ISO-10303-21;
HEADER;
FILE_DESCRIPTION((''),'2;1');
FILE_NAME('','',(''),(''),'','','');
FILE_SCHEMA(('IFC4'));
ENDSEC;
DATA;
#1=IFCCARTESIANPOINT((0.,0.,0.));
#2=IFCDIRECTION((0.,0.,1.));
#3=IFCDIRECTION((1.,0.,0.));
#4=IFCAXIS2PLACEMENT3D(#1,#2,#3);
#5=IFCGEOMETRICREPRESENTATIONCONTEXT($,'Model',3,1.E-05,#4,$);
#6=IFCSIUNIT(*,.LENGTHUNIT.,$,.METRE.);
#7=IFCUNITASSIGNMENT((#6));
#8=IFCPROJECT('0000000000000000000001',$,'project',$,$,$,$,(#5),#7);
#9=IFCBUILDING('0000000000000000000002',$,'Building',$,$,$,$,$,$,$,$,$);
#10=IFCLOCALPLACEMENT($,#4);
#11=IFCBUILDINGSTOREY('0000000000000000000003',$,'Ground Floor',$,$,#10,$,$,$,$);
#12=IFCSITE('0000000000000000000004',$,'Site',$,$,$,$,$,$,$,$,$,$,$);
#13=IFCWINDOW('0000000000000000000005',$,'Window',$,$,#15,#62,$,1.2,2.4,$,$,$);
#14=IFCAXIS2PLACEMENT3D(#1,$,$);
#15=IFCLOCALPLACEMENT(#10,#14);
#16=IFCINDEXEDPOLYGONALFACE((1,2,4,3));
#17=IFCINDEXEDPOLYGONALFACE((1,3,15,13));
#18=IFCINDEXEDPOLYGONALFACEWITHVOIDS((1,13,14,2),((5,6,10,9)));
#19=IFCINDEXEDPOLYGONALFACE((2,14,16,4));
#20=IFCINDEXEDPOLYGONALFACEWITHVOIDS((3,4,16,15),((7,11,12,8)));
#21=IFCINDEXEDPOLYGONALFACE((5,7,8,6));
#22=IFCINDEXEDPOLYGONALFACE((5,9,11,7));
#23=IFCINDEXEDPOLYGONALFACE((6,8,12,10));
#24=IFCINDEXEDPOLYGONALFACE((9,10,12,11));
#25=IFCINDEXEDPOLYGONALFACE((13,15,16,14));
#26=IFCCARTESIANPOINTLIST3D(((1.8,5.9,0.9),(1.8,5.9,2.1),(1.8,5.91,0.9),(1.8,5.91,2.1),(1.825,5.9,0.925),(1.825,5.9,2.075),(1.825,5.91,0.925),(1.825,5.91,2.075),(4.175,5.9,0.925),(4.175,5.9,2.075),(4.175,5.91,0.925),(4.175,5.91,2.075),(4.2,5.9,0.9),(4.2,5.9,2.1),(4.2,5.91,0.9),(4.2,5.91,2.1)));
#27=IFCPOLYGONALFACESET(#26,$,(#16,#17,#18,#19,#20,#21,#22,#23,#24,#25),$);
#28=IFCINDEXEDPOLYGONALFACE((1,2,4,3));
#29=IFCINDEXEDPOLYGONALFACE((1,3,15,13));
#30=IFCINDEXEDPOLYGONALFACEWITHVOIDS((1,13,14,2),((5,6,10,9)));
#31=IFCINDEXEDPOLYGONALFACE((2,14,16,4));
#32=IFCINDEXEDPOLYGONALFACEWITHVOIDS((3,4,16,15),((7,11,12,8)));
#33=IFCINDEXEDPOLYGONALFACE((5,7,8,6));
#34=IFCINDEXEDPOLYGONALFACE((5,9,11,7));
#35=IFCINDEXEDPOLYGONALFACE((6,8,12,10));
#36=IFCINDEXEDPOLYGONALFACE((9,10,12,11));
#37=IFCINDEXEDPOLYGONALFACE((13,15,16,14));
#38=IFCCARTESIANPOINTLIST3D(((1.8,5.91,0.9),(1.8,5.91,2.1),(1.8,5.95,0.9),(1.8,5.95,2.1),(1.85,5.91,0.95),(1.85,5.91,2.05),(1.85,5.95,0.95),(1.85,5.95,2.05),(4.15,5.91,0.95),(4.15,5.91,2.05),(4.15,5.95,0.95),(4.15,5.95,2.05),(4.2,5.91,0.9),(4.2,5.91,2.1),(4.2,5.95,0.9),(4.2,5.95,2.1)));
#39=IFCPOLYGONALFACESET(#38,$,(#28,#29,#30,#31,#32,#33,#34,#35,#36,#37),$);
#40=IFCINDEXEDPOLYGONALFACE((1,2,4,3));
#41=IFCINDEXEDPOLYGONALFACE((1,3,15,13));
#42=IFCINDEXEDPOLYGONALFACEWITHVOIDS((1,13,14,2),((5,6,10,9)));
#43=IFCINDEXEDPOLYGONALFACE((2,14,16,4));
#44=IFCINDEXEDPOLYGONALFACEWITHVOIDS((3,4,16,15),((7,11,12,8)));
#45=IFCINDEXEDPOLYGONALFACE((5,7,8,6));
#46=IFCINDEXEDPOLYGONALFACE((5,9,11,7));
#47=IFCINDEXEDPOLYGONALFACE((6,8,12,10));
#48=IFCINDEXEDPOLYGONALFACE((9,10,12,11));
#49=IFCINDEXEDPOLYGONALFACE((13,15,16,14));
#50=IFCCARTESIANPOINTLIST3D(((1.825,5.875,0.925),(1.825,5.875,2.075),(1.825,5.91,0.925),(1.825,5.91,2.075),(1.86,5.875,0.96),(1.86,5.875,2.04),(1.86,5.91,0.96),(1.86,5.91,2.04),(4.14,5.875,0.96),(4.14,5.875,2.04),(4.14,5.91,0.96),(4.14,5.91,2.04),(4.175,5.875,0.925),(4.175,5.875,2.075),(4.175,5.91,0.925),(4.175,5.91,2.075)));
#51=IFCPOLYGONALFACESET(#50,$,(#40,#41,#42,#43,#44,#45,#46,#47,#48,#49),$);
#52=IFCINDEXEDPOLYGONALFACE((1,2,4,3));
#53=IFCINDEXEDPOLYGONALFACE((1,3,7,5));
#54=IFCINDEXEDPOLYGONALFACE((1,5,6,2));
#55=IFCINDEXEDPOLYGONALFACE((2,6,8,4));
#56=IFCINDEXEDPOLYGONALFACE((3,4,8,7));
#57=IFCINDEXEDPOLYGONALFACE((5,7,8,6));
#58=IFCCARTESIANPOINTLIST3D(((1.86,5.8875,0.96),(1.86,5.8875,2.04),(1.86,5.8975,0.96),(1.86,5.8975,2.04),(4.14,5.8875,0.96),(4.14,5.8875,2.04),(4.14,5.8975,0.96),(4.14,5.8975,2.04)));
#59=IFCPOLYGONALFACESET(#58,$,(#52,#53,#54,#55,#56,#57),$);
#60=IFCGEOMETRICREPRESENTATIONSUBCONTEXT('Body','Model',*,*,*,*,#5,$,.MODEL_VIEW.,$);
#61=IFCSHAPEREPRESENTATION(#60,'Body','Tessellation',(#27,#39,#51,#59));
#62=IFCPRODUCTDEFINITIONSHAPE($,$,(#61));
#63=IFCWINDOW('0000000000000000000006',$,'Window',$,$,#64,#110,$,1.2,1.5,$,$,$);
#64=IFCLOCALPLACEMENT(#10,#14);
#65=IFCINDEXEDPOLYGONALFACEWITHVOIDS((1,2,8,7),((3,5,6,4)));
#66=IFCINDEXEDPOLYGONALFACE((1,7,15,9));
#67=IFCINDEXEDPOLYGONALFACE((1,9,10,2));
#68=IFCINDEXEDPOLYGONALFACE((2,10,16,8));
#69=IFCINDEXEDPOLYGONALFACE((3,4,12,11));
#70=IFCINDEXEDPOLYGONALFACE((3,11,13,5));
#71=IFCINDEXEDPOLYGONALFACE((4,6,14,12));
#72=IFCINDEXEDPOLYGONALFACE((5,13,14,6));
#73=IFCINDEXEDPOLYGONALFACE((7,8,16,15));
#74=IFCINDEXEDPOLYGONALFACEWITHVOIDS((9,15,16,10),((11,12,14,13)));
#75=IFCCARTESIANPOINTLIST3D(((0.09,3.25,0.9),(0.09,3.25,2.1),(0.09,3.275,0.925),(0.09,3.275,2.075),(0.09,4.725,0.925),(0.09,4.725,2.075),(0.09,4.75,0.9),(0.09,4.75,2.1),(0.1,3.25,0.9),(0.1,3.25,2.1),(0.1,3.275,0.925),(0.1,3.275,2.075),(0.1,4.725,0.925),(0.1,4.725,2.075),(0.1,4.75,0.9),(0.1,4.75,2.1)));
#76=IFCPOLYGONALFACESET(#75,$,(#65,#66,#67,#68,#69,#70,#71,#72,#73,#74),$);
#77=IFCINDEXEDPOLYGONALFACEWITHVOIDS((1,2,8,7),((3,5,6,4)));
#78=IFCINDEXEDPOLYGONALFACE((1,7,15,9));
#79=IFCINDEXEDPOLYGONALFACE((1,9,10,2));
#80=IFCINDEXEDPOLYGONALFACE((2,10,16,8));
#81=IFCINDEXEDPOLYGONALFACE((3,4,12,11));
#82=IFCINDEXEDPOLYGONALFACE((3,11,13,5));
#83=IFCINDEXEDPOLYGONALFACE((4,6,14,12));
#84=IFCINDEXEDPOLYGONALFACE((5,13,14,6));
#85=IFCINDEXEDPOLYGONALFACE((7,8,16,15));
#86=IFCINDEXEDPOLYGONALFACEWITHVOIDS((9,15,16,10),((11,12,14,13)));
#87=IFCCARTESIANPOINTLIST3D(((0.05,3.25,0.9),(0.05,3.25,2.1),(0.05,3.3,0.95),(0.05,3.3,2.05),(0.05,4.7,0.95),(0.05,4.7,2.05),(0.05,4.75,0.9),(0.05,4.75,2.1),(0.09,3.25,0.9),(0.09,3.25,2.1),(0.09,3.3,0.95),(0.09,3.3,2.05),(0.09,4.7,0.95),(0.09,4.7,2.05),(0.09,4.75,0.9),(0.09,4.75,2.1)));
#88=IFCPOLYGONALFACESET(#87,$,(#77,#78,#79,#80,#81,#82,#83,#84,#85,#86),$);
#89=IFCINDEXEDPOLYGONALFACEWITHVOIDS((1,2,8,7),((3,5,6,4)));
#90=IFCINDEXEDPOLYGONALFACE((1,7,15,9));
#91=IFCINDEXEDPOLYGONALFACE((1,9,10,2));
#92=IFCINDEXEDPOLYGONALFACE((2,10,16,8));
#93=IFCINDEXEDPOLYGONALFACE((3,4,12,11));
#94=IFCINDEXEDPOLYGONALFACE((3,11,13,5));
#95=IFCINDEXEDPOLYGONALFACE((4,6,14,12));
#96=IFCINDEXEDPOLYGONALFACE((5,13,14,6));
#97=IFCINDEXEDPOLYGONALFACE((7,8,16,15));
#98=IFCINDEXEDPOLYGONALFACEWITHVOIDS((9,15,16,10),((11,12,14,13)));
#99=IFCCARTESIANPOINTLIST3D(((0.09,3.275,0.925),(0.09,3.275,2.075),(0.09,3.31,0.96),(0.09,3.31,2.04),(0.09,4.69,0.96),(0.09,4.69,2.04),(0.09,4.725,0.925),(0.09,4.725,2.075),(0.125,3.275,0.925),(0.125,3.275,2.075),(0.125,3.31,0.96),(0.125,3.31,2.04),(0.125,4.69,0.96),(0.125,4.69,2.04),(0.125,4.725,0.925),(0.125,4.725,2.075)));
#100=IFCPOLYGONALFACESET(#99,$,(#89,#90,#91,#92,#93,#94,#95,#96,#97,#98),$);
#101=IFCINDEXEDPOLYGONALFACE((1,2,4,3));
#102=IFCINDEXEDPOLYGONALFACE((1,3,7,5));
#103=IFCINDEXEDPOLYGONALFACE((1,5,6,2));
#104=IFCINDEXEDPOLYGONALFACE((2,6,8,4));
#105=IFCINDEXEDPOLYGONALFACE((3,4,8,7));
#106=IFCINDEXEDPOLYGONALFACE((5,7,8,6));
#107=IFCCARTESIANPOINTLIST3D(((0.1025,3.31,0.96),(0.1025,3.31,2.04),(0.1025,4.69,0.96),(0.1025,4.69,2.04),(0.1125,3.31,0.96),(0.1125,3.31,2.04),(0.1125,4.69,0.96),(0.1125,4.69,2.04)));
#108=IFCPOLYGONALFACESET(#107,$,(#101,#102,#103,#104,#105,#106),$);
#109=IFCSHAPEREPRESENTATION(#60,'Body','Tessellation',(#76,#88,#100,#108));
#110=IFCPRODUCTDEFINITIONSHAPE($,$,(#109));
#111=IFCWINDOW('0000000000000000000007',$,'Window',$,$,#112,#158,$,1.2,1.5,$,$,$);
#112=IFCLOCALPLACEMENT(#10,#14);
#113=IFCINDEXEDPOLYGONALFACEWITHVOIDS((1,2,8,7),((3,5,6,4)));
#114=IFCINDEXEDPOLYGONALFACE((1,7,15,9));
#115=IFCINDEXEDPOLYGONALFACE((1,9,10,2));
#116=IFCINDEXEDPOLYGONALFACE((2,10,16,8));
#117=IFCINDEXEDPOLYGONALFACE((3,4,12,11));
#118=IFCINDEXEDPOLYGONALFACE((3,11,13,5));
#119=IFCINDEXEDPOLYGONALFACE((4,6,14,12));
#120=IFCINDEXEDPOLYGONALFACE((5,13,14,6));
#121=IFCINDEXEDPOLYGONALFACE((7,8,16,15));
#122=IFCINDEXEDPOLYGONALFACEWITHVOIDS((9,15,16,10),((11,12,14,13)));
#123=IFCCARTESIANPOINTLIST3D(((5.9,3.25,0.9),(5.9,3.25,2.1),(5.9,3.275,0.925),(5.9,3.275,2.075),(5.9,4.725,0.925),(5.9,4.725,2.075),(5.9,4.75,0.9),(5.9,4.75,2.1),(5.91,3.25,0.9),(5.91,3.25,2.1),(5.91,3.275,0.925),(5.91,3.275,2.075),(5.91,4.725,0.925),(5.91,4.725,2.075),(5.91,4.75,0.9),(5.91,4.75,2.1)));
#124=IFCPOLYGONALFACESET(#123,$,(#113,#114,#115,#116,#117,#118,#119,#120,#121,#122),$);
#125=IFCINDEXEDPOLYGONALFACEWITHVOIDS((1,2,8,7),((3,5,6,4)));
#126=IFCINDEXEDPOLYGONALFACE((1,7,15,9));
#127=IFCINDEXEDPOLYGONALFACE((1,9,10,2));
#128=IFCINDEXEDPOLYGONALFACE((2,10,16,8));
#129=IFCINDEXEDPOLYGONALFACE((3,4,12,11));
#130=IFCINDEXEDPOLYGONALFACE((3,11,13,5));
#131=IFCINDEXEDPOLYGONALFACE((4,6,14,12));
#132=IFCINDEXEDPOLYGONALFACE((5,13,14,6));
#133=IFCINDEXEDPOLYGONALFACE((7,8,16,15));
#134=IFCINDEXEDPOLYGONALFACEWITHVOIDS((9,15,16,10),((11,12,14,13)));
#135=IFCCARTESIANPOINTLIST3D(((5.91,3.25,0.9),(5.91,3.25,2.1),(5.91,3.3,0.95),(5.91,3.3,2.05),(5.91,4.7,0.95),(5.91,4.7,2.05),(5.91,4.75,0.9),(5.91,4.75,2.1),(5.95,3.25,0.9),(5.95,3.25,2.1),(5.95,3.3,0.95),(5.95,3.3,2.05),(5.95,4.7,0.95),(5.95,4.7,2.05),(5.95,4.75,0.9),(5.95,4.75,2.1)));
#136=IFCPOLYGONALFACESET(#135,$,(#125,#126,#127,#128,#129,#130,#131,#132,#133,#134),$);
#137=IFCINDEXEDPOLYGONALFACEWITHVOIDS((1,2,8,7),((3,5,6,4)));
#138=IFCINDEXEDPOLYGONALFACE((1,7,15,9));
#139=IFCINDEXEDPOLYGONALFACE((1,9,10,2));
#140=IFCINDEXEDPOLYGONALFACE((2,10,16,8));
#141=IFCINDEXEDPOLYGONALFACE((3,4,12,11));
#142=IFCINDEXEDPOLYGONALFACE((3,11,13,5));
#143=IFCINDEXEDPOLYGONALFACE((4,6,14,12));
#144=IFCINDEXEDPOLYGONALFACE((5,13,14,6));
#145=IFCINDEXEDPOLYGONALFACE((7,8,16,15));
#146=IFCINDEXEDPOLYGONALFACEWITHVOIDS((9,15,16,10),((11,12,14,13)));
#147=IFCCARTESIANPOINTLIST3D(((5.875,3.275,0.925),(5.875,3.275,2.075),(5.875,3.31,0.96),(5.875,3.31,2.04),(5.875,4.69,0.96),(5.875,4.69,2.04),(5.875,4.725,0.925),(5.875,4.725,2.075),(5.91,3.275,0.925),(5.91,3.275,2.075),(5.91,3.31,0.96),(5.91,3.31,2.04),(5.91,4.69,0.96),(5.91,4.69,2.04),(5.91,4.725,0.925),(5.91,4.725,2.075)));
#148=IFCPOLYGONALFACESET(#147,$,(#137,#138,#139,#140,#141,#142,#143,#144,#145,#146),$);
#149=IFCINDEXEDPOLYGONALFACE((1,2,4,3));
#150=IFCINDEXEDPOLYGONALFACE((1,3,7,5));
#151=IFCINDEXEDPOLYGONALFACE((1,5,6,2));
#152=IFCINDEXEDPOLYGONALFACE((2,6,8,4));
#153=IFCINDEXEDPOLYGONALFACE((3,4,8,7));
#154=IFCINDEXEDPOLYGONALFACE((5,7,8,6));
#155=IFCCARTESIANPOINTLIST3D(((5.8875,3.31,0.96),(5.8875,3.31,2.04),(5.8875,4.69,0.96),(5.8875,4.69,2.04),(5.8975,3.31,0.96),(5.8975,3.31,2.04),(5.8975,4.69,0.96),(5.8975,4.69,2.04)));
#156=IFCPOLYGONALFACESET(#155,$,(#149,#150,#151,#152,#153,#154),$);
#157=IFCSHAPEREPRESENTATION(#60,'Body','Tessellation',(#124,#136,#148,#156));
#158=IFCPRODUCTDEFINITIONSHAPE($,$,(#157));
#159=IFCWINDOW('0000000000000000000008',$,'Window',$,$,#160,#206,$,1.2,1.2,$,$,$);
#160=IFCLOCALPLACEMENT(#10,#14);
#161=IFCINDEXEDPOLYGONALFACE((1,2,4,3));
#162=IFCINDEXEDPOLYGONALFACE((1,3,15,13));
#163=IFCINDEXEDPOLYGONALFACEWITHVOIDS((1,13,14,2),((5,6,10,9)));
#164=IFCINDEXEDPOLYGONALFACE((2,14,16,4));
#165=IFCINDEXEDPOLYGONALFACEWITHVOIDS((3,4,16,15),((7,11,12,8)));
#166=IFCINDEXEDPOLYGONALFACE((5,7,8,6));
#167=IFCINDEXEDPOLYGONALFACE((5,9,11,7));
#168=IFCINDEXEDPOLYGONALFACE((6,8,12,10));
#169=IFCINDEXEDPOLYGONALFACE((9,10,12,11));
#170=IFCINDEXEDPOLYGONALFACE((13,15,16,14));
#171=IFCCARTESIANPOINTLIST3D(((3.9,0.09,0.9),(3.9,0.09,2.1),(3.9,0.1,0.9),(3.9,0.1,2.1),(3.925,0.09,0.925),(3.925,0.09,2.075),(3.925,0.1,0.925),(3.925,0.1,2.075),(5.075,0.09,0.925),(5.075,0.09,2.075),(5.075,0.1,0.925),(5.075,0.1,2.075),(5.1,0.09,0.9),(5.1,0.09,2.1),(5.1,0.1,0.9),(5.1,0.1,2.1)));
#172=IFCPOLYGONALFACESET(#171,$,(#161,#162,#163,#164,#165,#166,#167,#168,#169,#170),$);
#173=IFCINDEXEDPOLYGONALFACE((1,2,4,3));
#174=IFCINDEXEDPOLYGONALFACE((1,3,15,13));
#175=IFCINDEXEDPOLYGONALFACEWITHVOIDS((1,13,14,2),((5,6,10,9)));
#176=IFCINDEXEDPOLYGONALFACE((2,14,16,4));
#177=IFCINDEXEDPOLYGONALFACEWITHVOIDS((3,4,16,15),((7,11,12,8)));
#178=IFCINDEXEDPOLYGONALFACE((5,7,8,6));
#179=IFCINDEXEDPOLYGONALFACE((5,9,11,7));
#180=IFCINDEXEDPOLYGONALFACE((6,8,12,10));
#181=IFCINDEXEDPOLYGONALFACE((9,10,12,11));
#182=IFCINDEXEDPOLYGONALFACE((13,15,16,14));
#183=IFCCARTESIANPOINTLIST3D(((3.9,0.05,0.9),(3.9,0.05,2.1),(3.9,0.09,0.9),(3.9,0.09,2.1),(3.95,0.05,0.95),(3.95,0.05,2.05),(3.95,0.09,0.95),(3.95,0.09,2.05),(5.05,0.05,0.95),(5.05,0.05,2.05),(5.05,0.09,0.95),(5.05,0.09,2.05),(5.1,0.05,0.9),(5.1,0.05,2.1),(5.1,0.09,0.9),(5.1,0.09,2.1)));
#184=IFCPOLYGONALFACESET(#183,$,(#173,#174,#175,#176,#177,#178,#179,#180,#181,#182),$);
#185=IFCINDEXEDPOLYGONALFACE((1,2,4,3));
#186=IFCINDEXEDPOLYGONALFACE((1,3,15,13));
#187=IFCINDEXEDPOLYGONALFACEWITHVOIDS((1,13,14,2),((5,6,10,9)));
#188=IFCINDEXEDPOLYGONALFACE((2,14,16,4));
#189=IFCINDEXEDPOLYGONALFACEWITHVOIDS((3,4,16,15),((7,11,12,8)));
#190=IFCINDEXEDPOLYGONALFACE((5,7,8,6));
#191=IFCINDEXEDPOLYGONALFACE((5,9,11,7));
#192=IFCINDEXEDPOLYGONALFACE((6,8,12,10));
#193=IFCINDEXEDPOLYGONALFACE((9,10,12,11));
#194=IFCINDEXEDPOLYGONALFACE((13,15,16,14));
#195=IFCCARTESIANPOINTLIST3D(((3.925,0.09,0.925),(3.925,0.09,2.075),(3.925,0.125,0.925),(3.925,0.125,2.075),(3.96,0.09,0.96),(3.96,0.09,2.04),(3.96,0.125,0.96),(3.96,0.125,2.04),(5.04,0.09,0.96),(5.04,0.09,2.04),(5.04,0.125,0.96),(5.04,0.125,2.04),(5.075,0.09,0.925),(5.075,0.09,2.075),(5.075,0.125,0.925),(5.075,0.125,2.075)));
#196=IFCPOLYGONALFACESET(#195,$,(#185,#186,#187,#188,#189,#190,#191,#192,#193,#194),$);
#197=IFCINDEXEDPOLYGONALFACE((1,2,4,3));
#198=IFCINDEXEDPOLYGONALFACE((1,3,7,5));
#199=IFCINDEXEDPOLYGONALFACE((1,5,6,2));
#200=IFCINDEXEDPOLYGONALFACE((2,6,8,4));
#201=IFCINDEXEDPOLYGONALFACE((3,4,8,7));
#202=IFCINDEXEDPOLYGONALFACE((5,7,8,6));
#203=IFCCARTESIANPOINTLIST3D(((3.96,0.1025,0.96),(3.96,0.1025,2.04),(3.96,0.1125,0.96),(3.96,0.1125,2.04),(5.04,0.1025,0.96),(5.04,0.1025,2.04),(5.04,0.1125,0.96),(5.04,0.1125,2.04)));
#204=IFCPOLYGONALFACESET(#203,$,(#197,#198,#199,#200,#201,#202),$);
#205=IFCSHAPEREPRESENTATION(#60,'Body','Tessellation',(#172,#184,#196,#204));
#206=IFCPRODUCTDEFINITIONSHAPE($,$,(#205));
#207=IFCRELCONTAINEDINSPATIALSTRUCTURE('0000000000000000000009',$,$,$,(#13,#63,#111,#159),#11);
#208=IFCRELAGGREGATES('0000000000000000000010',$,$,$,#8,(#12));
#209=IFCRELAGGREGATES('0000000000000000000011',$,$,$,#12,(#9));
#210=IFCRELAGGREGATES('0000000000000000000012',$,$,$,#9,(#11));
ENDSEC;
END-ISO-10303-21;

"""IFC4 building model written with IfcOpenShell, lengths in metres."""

from ifc_helpers import new_model, si_unit, frame, origin_with_axes, place, context, subcontext, project, spatial, line, indexed_curve, outline, extrude, element, save


model = new_model("IFC4")

# Units and contexts
model_context = context("Model", 3, precision=1e-05, world=origin_with_axes())
body_context = subcontext(model_context, "Body", "Model", "MODEL_VIEW")
ifc_project = project(units=[si_unit("LENGTHUNIT", "METRE")], contexts=[model_context])

# Site, building, storey
site = spatial("IfcSite", under=ifc_project, Name="Site")
building = spatial("IfcBuilding", under=site, Name="Building")
storey_placement = place(None, origin_with_axes())
storey = spatial("IfcBuildingStorey", under=building, at=storey_placement, Name="Ground Floor")

# Windows
window_1_placement = place(storey_placement, frame((4.2, 6.0, 0.9), z_axis=(0.0, 0.0, 1.0), x_axis=(-1.0, 0.0, 0.0)))
element("IfcWindow", 1, at=window_1_placement, inside=storey, Name="Window", OverallHeight=1.2, OverallWidth=2.4, context=body_context, shape_type="SweptSolid", body=[
    extrude(outline(indexed_curve([(0.0, 0.0), (2.4, 0.0), (2.4, 1.2), (0.0, 1.2)], segments=[line(1, 2, 3, 4, 1)]), holes=[indexed_curve([(0.025, 0.025), (2.375, 0.025), (2.375, 1.175), (0.025, 1.175)], segments=[line(1, 2, 3, 4, 1)])]), frame((0.0, 0.09, 0.0), z_axis=(0.0, -1.0, 0.0), x_axis=(1.0, 0.0, 0.0)), (0.0, 0.0, -1.0), 0.01),
    extrude(outline(indexed_curve([(0.0, 0.0), (2.4, 0.0), (2.4, 1.2), (0.0, 1.2)], segments=[line(1, 2, 3, 4, 1)]), holes=[indexed_curve([(0.05, 0.05), (2.35, 0.05), (2.35, 1.15), (0.05, 1.15)], segments=[line(1, 2, 3, 4, 1)])]), frame((0.0, 0.05, 0.0), z_axis=(0.0, -1.0, 0.0), x_axis=(1.0, 0.0, 0.0)), (0.0, 0.0, -1.0), 0.04),
    extrude(outline(indexed_curve([(0.0, 0.0), (2.35, 0.0), (2.35, 1.15), (0.0, 1.15)], segments=[line(1, 2, 3, 4, 1)]), holes=[indexed_curve([(0.035, 0.035), (2.315, 0.035), (2.315, 1.115), (0.035, 1.115)], segments=[line(1, 2, 3, 4, 1)])]), frame((0.025, 0.09, 0.025), z_axis=(0.0, -1.0, 0.0), x_axis=(1.0, 0.0, 0.0)), (0.0, 0.0, -1.0), 0.035),
    extrude(outline(indexed_curve([(0.035, 0.035), (2.315, 0.035), (2.315, 1.115), (0.035, 1.115)], segments=[line(1, 2, 3, 4, 1)])), frame((0.025, 0.1025, 0.025), z_axis=(0.0, -1.0, 0.0), x_axis=(1.0, 0.0, 0.0)), (0.0, 0.0, -1.0), 0.01),
])
for number, where, z_axis, x_axis, name in (
    (2, (0.0, 4.75, 0.9), (0.0, 0.0, 1.0), (0.0, -1.0, 0.0), "Window"),
    (3, (6.0, 3.25, 0.9), (0.0, 0.0, 1.0), (0.0, 1.0, 0.0), "Window"),
):
    element("IfcWindow", number, at=place(storey_placement, frame(where, z_axis=z_axis, x_axis=x_axis)), inside=storey, Name=name, OverallHeight=1.2, OverallWidth=1.5, context=body_context, shape_type="SweptSolid", body=[
        extrude(outline(indexed_curve([(0.0, 0.0), (1.5, 0.0), (1.5, 1.2), (0.0, 1.2)], segments=[line(1, 2, 3, 4, 1)]), holes=[indexed_curve([(0.025, 0.025), (1.475, 0.025), (1.475, 1.175), (0.025, 1.175)], segments=[line(1, 2, 3, 4, 1)])]), frame((0.0, 0.09, 0.0), z_axis=(0.0, -1.0, 0.0), x_axis=(1.0, 0.0, 0.0)), (0.0, 0.0, -1.0), 0.01),
        extrude(outline(indexed_curve([(0.0, 0.0), (1.5, 0.0), (1.5, 1.2), (0.0, 1.2)], segments=[line(1, 2, 3, 4, 1)]), holes=[indexed_curve([(0.05, 0.05), (1.45, 0.05), (1.45, 1.15), (0.05, 1.15)], segments=[line(1, 2, 3, 4, 1)])]), frame((0.0, 0.05, 0.0), z_axis=(0.0, -1.0, 0.0), x_axis=(1.0, 0.0, 0.0)), (0.0, 0.0, -1.0), 0.04),
        extrude(outline(indexed_curve([(0.0, 0.0), (1.45, 0.0), (1.45, 1.15), (0.0, 1.15)], segments=[line(1, 2, 3, 4, 1)]), holes=[indexed_curve([(0.035, 0.035), (1.415, 0.035), (1.415, 1.115), (0.035, 1.115)], segments=[line(1, 2, 3, 4, 1)])]), frame((0.025, 0.09, 0.025), z_axis=(0.0, -1.0, 0.0), x_axis=(1.0, 0.0, 0.0)), (0.0, 0.0, -1.0), 0.035),
        extrude(outline(indexed_curve([(0.035, 0.035), (1.415, 0.035), (1.415, 1.115), (0.035, 1.115)], segments=[line(1, 2, 3, 4, 1)])), frame((0.025, 0.1025, 0.025), z_axis=(0.0, -1.0, 0.0), x_axis=(1.0, 0.0, 0.0)), (0.0, 0.0, -1.0), 0.01),
    ])
window_2_placement = place(storey_placement, frame((3.9, 0.0, 0.9), z_axis=(0.0, 0.0, 1.0), x_axis=(1.0, 0.0, 0.0)))
element("IfcWindow", 4, at=window_2_placement, inside=storey, Name="Window", OverallHeight=1.2, OverallWidth=1.2, context=body_context, shape_type="SweptSolid", body=[
    extrude(outline(indexed_curve([(0.0, 0.0), (1.2, 0.0), (1.2, 1.2), (0.0, 1.2)], segments=[line(1, 2, 3, 4, 1)]), holes=[indexed_curve([(0.025, 0.025), (1.175, 0.025), (1.175, 1.175), (0.025, 1.175)], segments=[line(1, 2, 3, 4, 1)])]), frame((0.0, 0.09, 0.0), z_axis=(0.0, -1.0, 0.0), x_axis=(1.0, 0.0, 0.0)), (0.0, 0.0, -1.0), 0.01),
    extrude(outline(indexed_curve([(0.0, 0.0), (1.2, 0.0), (1.2, 1.2), (0.0, 1.2)], segments=[line(1, 2, 3, 4, 1)]), holes=[indexed_curve([(0.05, 0.05), (1.15, 0.05), (1.15, 1.15), (0.05, 1.15)], segments=[line(1, 2, 3, 4, 1)])]), frame((0.0, 0.05, 0.0), z_axis=(0.0, -1.0, 0.0), x_axis=(1.0, 0.0, 0.0)), (0.0, 0.0, -1.0), 0.04),
    extrude(outline(indexed_curve([(0.0, 0.0), (1.15, 0.0), (1.15, 1.15), (0.0, 1.15)], segments=[line(1, 2, 3, 4, 1)]), holes=[indexed_curve([(0.035, 0.035), (1.115, 0.035), (1.115, 1.115), (0.035, 1.115)], segments=[line(1, 2, 3, 4, 1)])]), frame((0.025, 0.09, 0.025), z_axis=(0.0, -1.0, 0.0), x_axis=(1.0, 0.0, 0.0)), (0.0, 0.0, -1.0), 0.035),
    extrude(outline(indexed_curve([(0.035, 0.035), (1.115, 0.035), (1.115, 1.115), (0.035, 1.115)], segments=[line(1, 2, 3, 4, 1)])), frame((0.025, 0.1025, 0.025), z_axis=(0.0, -1.0, 0.0), x_axis=(1.0, 0.0, 0.0)), (0.0, 0.0, -1.0), 0.01),
])

save(model, "model.ifc")
